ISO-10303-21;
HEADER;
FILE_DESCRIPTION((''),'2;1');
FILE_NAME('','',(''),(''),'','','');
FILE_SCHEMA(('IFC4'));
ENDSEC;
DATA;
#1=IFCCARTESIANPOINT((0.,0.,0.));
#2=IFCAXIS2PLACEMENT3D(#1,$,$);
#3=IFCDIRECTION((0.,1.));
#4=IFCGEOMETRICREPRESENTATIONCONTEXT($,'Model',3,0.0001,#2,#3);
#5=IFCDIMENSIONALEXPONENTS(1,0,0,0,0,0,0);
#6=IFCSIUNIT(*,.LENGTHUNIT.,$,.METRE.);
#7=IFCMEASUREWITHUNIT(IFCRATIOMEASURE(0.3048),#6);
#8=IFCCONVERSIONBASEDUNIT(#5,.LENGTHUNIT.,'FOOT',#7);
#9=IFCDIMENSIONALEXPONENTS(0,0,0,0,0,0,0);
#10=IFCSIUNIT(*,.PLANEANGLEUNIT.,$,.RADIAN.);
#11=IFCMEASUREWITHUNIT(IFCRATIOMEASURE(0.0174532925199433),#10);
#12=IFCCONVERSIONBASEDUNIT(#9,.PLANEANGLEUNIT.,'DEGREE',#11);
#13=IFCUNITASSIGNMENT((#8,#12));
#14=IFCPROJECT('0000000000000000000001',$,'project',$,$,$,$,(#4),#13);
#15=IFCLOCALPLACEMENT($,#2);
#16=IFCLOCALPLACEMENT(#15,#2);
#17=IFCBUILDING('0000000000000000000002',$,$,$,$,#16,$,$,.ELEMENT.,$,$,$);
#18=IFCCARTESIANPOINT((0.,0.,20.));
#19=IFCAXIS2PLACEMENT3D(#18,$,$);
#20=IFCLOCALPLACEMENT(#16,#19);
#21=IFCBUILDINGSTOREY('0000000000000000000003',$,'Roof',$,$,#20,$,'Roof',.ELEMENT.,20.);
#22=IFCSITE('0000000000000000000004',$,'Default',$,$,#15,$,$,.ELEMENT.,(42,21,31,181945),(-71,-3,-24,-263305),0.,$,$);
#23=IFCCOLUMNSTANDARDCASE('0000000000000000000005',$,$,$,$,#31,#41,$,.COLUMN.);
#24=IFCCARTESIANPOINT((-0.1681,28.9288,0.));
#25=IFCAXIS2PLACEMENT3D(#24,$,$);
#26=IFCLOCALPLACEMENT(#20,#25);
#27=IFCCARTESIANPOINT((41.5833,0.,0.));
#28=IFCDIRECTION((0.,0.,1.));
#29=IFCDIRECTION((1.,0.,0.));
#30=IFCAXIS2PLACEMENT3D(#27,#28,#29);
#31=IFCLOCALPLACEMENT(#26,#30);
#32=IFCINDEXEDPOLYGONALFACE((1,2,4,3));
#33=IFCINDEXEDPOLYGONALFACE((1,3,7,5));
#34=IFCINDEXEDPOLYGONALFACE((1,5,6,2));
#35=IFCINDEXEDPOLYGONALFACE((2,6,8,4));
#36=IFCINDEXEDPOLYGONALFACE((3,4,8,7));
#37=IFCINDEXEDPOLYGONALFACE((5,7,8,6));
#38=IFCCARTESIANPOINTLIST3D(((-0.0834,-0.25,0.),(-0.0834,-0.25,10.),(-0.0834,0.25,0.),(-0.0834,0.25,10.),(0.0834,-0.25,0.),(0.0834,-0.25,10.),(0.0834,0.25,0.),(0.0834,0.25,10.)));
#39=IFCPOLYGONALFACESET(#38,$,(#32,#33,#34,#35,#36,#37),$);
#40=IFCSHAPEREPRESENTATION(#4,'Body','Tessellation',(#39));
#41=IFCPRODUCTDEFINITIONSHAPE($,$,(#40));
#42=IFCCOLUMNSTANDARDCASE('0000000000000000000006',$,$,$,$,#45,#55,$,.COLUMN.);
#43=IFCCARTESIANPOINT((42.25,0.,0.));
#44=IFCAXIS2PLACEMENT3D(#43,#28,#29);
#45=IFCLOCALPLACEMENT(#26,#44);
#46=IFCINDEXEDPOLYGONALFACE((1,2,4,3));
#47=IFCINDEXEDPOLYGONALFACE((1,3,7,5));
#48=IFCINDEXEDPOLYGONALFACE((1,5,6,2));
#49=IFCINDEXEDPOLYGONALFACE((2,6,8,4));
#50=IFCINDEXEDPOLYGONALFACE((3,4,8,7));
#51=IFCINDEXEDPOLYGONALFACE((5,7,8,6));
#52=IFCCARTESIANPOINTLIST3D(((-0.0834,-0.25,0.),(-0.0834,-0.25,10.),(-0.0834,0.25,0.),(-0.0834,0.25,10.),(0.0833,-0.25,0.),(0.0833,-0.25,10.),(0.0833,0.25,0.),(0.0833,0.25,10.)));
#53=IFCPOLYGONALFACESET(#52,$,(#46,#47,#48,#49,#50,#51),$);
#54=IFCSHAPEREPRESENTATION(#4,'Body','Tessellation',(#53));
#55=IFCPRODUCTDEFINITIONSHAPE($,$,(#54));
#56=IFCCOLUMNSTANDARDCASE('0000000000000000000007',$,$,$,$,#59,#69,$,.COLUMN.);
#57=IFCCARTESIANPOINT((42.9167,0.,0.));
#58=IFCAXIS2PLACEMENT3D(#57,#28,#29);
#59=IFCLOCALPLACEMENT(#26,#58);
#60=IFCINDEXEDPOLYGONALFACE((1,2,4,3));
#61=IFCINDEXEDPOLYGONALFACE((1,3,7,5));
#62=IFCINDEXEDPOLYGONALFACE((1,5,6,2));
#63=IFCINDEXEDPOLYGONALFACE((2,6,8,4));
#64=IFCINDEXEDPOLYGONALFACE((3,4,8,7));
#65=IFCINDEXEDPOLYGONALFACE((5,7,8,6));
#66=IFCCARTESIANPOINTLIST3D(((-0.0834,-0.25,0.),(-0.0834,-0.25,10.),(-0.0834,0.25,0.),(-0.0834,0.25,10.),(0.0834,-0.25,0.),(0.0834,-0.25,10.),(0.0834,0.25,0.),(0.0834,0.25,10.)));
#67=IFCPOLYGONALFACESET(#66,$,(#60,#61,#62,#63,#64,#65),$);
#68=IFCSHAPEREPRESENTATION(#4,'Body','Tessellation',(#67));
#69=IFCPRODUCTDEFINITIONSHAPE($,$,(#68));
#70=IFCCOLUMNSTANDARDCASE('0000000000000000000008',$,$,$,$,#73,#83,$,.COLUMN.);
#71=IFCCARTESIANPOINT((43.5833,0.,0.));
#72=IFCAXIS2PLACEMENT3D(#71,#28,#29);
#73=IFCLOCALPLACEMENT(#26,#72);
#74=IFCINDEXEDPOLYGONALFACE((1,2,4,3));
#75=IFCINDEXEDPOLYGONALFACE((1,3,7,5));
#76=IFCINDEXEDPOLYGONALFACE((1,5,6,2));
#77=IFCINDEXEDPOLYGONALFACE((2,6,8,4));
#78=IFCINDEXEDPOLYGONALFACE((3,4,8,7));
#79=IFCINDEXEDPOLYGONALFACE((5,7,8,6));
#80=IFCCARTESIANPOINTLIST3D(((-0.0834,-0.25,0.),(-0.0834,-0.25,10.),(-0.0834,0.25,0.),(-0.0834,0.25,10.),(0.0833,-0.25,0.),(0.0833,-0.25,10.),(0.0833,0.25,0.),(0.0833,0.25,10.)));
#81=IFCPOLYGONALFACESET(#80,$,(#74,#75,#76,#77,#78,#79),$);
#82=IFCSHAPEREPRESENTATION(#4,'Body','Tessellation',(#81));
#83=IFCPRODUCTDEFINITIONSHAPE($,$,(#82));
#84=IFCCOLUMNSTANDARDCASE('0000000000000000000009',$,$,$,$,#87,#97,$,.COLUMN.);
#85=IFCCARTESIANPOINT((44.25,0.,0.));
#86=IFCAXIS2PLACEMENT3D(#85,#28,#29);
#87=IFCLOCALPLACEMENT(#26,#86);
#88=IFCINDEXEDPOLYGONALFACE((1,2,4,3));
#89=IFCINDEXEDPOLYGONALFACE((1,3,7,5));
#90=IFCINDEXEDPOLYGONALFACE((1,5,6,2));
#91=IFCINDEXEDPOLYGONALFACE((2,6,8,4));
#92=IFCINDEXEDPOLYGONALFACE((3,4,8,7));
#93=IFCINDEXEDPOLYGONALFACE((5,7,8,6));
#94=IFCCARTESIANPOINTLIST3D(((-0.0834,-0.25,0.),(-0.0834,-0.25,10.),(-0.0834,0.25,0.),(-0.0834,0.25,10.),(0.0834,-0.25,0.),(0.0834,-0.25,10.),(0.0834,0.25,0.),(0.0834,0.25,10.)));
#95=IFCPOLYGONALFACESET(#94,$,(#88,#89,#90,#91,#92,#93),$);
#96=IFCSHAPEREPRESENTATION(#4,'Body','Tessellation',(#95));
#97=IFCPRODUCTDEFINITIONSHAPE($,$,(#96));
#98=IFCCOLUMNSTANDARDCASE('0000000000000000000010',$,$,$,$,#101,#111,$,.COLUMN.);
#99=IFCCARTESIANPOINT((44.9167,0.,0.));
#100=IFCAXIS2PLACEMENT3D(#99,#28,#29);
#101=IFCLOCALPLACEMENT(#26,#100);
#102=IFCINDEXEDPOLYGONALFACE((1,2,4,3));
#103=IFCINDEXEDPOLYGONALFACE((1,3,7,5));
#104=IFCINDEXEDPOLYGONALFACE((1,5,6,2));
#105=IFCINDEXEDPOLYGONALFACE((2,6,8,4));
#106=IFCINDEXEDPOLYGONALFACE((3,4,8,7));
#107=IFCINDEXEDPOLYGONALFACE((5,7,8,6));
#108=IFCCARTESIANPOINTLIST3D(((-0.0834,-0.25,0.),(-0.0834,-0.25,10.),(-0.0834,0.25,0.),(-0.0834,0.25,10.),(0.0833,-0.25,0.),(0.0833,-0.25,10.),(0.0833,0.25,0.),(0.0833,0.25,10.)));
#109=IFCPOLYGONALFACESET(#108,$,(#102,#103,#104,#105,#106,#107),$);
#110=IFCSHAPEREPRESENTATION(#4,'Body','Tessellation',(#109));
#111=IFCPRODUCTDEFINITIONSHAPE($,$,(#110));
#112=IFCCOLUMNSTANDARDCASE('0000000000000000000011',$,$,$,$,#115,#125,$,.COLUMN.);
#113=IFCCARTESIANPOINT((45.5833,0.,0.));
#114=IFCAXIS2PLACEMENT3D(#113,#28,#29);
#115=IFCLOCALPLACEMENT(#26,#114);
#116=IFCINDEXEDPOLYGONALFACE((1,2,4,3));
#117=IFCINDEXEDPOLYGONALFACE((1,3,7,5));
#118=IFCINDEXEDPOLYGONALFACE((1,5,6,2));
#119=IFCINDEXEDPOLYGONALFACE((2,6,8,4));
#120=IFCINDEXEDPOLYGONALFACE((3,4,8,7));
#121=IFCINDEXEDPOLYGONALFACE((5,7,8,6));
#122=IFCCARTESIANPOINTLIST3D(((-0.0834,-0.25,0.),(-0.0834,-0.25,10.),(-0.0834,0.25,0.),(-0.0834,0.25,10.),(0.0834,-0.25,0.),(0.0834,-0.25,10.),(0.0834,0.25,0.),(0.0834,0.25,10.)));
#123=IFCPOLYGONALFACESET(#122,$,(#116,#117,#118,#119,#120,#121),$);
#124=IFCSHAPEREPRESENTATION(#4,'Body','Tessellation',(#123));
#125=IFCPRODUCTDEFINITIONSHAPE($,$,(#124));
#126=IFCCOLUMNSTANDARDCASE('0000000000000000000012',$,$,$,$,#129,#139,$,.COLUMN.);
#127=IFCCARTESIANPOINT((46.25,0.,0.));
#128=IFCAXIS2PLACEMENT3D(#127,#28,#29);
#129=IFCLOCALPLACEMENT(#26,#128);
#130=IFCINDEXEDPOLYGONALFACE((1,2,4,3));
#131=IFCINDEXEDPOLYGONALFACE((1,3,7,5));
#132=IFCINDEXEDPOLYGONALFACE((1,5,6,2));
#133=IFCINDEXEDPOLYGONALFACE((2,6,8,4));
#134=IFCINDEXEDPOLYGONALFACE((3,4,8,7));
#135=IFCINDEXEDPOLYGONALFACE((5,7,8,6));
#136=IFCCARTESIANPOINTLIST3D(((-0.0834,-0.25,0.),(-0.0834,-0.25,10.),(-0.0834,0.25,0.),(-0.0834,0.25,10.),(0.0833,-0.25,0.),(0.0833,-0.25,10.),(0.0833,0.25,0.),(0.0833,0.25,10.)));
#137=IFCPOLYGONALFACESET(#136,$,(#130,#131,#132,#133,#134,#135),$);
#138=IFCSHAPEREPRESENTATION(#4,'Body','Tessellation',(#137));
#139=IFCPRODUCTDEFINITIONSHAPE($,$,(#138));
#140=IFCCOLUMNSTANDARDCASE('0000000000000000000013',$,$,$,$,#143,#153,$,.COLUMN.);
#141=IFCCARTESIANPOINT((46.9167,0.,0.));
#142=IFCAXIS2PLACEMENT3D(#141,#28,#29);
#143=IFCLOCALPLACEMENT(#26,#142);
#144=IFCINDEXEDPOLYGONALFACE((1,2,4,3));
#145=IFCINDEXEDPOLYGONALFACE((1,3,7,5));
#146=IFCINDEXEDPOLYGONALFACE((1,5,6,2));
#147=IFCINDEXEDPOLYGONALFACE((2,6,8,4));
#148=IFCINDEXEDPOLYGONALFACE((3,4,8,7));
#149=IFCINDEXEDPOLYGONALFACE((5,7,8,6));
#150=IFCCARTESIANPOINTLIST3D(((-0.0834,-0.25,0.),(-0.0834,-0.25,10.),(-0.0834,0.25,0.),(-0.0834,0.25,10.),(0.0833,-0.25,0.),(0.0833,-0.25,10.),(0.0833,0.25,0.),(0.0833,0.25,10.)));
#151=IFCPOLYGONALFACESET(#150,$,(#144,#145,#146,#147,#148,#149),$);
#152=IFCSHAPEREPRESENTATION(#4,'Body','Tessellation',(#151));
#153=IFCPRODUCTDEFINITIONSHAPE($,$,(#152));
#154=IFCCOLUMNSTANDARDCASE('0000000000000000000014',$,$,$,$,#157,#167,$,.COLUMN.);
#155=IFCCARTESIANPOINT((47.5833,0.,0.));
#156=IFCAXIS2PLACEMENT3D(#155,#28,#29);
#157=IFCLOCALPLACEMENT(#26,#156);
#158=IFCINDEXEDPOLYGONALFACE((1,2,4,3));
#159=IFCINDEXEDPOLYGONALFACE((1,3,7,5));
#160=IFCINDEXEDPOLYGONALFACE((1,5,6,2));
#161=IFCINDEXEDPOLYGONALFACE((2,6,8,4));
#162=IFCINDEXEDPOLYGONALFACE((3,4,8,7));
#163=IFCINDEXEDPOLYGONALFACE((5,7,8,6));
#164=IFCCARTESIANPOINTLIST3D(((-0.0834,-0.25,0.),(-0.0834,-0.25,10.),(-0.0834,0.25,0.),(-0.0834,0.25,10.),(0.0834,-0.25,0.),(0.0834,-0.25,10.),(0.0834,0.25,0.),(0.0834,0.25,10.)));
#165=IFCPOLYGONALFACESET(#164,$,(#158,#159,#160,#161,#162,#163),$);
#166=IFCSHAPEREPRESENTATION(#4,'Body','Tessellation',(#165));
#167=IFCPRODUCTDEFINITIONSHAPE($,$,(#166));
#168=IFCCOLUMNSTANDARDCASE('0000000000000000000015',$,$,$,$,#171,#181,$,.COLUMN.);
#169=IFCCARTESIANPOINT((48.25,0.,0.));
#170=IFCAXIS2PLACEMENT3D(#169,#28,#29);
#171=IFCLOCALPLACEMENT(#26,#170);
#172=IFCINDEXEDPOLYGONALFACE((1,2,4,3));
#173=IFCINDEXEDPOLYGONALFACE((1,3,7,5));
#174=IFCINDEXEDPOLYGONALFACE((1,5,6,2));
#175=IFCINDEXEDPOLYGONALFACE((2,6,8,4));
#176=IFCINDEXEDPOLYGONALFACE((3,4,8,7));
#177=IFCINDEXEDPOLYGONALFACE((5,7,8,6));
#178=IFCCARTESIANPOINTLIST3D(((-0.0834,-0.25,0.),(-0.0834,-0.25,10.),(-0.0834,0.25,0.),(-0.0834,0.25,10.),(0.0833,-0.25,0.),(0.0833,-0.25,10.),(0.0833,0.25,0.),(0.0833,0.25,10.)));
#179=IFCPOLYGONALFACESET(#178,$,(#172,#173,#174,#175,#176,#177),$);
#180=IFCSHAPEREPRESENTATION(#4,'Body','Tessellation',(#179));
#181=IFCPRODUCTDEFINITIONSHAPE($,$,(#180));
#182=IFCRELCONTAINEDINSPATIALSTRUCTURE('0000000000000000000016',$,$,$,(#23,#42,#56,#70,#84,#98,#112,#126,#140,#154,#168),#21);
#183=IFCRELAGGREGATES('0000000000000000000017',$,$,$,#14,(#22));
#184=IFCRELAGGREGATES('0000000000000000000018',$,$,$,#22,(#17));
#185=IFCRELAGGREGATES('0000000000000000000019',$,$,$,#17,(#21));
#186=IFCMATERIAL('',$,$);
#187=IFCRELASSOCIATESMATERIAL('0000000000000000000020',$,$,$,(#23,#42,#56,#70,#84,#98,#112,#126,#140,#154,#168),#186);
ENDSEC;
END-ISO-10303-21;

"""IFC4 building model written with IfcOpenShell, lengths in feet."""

from ifc_helpers import new_model, entity, si_unit, converted_unit, direction, frame, origin, place, context, project, spatial, rectangle, extrude, material, element, save


model = new_model("IFC4")

# Units and contexts
model_context = context("Model", 3, precision=0.0001, world=origin(), true_north=direction((0.0, 1.0)))
ifc_project = project(units=[converted_unit("LENGTHUNIT", "FOOT", entity("IfcRatioMeasure", 0.3048), si_unit("LENGTHUNIT", "METRE"), dimensions=[1, 0, 0, 0, 0, 0, 0]), converted_unit("PLANEANGLEUNIT", "DEGREE", entity("IfcRatioMeasure", 0.0174532925199433), si_unit("PLANEANGLEUNIT", "RADIAN"), dimensions=[0, 0, 0, 0, 0, 0, 0])], contexts=[model_context])

# Site, building, storey
site_placement = place(None, origin())
site = spatial("IfcSite", under=ifc_project, at=site_placement, Name="Default", CompositionType="ELEMENT", RefLatitude=(42, 21, 31, 181945), RefLongitude=(-71, -3, -24, -263305), RefElevation=0.0)
building_placement = place(site_placement, origin())
building = spatial("IfcBuilding", under=site, at=building_placement, CompositionType="ELEMENT")
storey_placement = place(building_placement, frame((0.0, 0.0, 20.0)))
storey = spatial("IfcBuildingStorey", under=building, at=storey_placement, Name="Roof", LongName="Roof", CompositionType="ELEMENT", Elevation=20.0)

# Columns
ifc_material = material(Name="")
placement = place(storey_placement, frame((-0.1681, 28.9288, 0.0)))
for number, where, z_axis, x_axis in (
    (1, (41.5833, 0.0, 0.0), (0.0, 0.0, 1.0), (1.0, 0.0, 0.0)),
    (2, (42.25, 0.0, 0.0), (0.0, 0.0, 1.0), (1.0, 0.0, 0.0)),
    (3, (42.9167, 0.0, 0.0), (0.0, 0.0, 1.0), (1.0, 0.0, 0.0)),
    (4, (43.5833, 0.0, 0.0), (0.0, 0.0, 1.0), (1.0, 0.0, 0.0)),
    (5, (44.25, 0.0, 0.0), (0.0, 0.0, 1.0), (1.0, 0.0, 0.0)),
    (6, (44.9167, 0.0, 0.0), (0.0, 0.0, 1.0), (1.0, 0.0, 0.0)),
    (7, (45.5833, 0.0, 0.0), (0.0, 0.0, 1.0), (1.0, 0.0, 0.0)),
    (8, (46.25, 0.0, 0.0), (0.0, 0.0, 1.0), (1.0, 0.0, 0.0)),
    (9, (46.9167, 0.0, 0.0), (0.0, 0.0, 1.0), (1.0, 0.0, 0.0)),
    (10, (47.5833, 0.0, 0.0), (0.0, 0.0, 1.0), (1.0, 0.0, 0.0)),
    (11, (48.25, 0.0, 0.0), (0.0, 0.0, 1.0), (1.0, 0.0, 0.0)),
):
    element("IfcColumnStandardCase", number, at=place(placement, frame(where, z_axis=z_axis, x_axis=x_axis)), inside=storey, material=ifc_material, PredefinedType="COLUMN", context=model_context, shape_type="SweptSolid", body=[
        extrude(rectangle(XDim=0.1667, YDim=0.5), origin(), (0.0, 0.0, 1.0), 10.0),
    ])

save(model, "model.ifc")
